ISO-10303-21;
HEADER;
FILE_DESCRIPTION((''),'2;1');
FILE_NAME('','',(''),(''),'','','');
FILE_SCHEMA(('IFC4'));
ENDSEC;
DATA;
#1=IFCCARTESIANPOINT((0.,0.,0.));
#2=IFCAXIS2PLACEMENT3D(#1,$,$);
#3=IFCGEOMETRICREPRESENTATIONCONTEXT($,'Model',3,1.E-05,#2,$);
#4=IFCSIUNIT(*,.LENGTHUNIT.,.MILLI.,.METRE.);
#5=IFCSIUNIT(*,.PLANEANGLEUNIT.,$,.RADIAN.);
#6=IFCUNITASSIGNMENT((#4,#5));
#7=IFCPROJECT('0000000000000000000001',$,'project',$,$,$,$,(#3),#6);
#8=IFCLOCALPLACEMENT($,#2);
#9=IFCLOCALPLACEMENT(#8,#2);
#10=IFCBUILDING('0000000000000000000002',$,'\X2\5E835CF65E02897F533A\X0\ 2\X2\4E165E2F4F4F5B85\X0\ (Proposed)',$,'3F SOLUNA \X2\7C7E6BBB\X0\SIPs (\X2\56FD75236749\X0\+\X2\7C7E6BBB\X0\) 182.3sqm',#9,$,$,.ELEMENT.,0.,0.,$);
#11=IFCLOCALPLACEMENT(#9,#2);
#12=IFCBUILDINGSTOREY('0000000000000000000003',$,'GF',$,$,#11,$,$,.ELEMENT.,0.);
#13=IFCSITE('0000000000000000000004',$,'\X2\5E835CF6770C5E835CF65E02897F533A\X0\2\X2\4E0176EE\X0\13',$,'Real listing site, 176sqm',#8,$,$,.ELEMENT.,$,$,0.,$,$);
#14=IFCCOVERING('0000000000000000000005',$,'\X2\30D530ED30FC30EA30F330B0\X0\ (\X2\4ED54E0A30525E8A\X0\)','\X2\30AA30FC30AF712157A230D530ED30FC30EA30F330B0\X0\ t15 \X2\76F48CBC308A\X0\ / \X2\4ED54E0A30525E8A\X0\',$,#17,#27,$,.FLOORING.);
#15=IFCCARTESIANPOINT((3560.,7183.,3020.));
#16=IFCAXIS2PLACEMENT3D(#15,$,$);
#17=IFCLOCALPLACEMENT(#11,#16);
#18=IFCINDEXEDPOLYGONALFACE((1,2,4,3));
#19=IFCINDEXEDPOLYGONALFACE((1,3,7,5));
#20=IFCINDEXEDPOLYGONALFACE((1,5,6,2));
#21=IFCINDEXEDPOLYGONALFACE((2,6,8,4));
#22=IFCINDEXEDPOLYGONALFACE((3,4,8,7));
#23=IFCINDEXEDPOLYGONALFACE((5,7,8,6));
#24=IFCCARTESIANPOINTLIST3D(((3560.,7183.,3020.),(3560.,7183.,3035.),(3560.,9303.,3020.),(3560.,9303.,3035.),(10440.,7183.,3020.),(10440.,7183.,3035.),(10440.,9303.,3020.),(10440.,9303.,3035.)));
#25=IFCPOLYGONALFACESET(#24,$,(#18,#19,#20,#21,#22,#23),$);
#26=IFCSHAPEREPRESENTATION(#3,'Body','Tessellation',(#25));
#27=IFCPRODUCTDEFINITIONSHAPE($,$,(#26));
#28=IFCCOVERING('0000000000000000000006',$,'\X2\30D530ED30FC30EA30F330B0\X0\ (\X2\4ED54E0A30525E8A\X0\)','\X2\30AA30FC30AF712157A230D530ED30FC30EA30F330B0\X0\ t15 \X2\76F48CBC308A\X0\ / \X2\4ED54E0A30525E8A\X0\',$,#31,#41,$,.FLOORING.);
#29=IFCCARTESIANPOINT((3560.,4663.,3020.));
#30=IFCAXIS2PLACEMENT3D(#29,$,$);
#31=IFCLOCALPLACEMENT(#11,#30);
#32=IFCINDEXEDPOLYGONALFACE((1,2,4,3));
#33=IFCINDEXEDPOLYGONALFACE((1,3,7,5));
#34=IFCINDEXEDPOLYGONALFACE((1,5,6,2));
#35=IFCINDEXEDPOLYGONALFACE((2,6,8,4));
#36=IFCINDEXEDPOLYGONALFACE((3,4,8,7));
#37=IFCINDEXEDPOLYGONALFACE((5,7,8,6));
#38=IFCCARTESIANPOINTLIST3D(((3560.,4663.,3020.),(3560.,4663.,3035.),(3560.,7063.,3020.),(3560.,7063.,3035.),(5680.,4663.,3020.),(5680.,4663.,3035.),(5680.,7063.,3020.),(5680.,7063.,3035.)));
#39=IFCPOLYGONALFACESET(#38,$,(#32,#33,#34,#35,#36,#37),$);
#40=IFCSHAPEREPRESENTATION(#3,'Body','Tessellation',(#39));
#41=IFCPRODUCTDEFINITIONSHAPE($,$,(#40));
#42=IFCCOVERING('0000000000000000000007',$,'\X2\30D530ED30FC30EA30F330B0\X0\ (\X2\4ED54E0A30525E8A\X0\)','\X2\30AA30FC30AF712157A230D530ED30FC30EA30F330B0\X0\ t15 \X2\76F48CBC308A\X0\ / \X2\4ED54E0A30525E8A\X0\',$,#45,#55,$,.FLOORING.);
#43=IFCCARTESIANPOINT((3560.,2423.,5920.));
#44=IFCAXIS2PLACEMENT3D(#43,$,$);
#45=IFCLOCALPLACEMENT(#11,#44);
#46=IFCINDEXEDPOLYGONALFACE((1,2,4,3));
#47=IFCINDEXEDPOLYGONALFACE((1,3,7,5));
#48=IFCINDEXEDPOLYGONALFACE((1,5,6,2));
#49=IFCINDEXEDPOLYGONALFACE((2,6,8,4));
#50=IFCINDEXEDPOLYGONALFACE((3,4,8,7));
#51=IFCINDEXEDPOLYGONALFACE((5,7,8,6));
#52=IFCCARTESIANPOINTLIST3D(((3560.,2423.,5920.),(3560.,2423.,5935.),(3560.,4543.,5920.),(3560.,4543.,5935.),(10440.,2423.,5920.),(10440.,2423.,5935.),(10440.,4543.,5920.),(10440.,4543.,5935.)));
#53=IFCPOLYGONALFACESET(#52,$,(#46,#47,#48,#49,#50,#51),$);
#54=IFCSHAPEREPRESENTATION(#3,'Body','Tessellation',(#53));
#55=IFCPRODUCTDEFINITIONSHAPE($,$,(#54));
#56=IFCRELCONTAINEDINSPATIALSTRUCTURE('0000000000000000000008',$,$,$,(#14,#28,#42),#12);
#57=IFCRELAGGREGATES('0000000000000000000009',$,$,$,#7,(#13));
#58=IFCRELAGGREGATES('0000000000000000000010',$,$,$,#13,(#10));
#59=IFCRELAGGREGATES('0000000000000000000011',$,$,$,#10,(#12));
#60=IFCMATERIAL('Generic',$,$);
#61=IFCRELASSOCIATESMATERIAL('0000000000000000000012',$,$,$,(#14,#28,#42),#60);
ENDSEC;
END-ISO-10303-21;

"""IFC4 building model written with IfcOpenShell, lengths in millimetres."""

from ifc_helpers import new_model, si_unit, frame, frame_2d, origin, place, context, project, spatial, rectangle, extrude, material, element, save


model = new_model("IFC4")

# Units and contexts
model_context = context("Model", 3, precision=1e-05, world=origin())
ifc_project = project(units=[si_unit("LENGTHUNIT", "METRE", prefix="MILLI"), si_unit("PLANEANGLEUNIT", "RADIAN")], contexts=[model_context])

# Site, building, storey
site_placement = place(None, origin())
site = spatial("IfcSite", under=ifc_project, at=site_placement, Name="広島県広島市西区2丁目13", ObjectType="Real listing site, 176sqm", CompositionType="ELEMENT", RefElevation=0.0)
building_placement = place(site_placement, origin())
building = spatial("IfcBuilding", under=site, at=building_placement, Name="広島市西区 2世帯住宅 (Proposed)", ObjectType="3F SOLUNA 籾殻SIPs (国産杉+籾殻) 182.3sqm", CompositionType="ELEMENT", ElevationOfRefHeight=0.0, ElevationOfTerrain=0.0)
storey_placement = place(building_placement, origin())
storey = spatial("IfcBuildingStorey", under=building, at=storey_placement, Name="GF", CompositionType="ELEMENT", Elevation=0.0)

# Shared definitions
ifc_material_1 = material(Name="Generic")

# Coverings
covering_1_placement = place(storey_placement, frame((3560.0, 7183.0, 3020.0)))
element("IfcCovering", 1, at=covering_1_placement, inside=storey, material=ifc_material_1, Name="フローリング (仕上げ床)", Description="オーク無垢フローリング t15 直貼り / 仕上げ床", PredefinedType="FLOORING", context=model_context, shape_type="SweptSolid", body=[
    extrude(rectangle(XDim=6880.0, YDim=2120.0, at=frame_2d((3440.0, 1060.0))), frame((3560.0, 7183.0, 3020.0)), (0.0, 0.0, 1.0), 15.0),
])
covering_2_placement = place(storey_placement, frame((3560.0, 4663.0, 3020.0)))
element("IfcCovering", 2, at=covering_2_placement, inside=storey, material=ifc_material_1, Name="フローリング (仕上げ床)", Description="オーク無垢フローリング t15 直貼り / 仕上げ床", PredefinedType="FLOORING", context=model_context, shape_type="SweptSolid", body=[
    extrude(rectangle(XDim=2120.0, YDim=2400.0, at=frame_2d((1060.0, 1200.0))), frame((3560.0, 4663.0, 3020.0)), (0.0, 0.0, 1.0), 15.0),
])
covering_3_placement = place(storey_placement, frame((3560.0, 2423.0, 5920.0)))
element("IfcCovering", 3, at=covering_3_placement, inside=storey, material=ifc_material_1, Name="フローリング (仕上げ床)", Description="オーク無垢フローリング t15 直貼り / 仕上げ床", PredefinedType="FLOORING", context=model_context, shape_type="SweptSolid", body=[
    extrude(rectangle(XDim=6880.0, YDim=2120.0, at=frame_2d((3440.0, 1060.0))), frame((3560.0, 2423.0, 5920.0)), (0.0, 0.0, 1.0), 15.0),
])

save(model, "model.ifc")
